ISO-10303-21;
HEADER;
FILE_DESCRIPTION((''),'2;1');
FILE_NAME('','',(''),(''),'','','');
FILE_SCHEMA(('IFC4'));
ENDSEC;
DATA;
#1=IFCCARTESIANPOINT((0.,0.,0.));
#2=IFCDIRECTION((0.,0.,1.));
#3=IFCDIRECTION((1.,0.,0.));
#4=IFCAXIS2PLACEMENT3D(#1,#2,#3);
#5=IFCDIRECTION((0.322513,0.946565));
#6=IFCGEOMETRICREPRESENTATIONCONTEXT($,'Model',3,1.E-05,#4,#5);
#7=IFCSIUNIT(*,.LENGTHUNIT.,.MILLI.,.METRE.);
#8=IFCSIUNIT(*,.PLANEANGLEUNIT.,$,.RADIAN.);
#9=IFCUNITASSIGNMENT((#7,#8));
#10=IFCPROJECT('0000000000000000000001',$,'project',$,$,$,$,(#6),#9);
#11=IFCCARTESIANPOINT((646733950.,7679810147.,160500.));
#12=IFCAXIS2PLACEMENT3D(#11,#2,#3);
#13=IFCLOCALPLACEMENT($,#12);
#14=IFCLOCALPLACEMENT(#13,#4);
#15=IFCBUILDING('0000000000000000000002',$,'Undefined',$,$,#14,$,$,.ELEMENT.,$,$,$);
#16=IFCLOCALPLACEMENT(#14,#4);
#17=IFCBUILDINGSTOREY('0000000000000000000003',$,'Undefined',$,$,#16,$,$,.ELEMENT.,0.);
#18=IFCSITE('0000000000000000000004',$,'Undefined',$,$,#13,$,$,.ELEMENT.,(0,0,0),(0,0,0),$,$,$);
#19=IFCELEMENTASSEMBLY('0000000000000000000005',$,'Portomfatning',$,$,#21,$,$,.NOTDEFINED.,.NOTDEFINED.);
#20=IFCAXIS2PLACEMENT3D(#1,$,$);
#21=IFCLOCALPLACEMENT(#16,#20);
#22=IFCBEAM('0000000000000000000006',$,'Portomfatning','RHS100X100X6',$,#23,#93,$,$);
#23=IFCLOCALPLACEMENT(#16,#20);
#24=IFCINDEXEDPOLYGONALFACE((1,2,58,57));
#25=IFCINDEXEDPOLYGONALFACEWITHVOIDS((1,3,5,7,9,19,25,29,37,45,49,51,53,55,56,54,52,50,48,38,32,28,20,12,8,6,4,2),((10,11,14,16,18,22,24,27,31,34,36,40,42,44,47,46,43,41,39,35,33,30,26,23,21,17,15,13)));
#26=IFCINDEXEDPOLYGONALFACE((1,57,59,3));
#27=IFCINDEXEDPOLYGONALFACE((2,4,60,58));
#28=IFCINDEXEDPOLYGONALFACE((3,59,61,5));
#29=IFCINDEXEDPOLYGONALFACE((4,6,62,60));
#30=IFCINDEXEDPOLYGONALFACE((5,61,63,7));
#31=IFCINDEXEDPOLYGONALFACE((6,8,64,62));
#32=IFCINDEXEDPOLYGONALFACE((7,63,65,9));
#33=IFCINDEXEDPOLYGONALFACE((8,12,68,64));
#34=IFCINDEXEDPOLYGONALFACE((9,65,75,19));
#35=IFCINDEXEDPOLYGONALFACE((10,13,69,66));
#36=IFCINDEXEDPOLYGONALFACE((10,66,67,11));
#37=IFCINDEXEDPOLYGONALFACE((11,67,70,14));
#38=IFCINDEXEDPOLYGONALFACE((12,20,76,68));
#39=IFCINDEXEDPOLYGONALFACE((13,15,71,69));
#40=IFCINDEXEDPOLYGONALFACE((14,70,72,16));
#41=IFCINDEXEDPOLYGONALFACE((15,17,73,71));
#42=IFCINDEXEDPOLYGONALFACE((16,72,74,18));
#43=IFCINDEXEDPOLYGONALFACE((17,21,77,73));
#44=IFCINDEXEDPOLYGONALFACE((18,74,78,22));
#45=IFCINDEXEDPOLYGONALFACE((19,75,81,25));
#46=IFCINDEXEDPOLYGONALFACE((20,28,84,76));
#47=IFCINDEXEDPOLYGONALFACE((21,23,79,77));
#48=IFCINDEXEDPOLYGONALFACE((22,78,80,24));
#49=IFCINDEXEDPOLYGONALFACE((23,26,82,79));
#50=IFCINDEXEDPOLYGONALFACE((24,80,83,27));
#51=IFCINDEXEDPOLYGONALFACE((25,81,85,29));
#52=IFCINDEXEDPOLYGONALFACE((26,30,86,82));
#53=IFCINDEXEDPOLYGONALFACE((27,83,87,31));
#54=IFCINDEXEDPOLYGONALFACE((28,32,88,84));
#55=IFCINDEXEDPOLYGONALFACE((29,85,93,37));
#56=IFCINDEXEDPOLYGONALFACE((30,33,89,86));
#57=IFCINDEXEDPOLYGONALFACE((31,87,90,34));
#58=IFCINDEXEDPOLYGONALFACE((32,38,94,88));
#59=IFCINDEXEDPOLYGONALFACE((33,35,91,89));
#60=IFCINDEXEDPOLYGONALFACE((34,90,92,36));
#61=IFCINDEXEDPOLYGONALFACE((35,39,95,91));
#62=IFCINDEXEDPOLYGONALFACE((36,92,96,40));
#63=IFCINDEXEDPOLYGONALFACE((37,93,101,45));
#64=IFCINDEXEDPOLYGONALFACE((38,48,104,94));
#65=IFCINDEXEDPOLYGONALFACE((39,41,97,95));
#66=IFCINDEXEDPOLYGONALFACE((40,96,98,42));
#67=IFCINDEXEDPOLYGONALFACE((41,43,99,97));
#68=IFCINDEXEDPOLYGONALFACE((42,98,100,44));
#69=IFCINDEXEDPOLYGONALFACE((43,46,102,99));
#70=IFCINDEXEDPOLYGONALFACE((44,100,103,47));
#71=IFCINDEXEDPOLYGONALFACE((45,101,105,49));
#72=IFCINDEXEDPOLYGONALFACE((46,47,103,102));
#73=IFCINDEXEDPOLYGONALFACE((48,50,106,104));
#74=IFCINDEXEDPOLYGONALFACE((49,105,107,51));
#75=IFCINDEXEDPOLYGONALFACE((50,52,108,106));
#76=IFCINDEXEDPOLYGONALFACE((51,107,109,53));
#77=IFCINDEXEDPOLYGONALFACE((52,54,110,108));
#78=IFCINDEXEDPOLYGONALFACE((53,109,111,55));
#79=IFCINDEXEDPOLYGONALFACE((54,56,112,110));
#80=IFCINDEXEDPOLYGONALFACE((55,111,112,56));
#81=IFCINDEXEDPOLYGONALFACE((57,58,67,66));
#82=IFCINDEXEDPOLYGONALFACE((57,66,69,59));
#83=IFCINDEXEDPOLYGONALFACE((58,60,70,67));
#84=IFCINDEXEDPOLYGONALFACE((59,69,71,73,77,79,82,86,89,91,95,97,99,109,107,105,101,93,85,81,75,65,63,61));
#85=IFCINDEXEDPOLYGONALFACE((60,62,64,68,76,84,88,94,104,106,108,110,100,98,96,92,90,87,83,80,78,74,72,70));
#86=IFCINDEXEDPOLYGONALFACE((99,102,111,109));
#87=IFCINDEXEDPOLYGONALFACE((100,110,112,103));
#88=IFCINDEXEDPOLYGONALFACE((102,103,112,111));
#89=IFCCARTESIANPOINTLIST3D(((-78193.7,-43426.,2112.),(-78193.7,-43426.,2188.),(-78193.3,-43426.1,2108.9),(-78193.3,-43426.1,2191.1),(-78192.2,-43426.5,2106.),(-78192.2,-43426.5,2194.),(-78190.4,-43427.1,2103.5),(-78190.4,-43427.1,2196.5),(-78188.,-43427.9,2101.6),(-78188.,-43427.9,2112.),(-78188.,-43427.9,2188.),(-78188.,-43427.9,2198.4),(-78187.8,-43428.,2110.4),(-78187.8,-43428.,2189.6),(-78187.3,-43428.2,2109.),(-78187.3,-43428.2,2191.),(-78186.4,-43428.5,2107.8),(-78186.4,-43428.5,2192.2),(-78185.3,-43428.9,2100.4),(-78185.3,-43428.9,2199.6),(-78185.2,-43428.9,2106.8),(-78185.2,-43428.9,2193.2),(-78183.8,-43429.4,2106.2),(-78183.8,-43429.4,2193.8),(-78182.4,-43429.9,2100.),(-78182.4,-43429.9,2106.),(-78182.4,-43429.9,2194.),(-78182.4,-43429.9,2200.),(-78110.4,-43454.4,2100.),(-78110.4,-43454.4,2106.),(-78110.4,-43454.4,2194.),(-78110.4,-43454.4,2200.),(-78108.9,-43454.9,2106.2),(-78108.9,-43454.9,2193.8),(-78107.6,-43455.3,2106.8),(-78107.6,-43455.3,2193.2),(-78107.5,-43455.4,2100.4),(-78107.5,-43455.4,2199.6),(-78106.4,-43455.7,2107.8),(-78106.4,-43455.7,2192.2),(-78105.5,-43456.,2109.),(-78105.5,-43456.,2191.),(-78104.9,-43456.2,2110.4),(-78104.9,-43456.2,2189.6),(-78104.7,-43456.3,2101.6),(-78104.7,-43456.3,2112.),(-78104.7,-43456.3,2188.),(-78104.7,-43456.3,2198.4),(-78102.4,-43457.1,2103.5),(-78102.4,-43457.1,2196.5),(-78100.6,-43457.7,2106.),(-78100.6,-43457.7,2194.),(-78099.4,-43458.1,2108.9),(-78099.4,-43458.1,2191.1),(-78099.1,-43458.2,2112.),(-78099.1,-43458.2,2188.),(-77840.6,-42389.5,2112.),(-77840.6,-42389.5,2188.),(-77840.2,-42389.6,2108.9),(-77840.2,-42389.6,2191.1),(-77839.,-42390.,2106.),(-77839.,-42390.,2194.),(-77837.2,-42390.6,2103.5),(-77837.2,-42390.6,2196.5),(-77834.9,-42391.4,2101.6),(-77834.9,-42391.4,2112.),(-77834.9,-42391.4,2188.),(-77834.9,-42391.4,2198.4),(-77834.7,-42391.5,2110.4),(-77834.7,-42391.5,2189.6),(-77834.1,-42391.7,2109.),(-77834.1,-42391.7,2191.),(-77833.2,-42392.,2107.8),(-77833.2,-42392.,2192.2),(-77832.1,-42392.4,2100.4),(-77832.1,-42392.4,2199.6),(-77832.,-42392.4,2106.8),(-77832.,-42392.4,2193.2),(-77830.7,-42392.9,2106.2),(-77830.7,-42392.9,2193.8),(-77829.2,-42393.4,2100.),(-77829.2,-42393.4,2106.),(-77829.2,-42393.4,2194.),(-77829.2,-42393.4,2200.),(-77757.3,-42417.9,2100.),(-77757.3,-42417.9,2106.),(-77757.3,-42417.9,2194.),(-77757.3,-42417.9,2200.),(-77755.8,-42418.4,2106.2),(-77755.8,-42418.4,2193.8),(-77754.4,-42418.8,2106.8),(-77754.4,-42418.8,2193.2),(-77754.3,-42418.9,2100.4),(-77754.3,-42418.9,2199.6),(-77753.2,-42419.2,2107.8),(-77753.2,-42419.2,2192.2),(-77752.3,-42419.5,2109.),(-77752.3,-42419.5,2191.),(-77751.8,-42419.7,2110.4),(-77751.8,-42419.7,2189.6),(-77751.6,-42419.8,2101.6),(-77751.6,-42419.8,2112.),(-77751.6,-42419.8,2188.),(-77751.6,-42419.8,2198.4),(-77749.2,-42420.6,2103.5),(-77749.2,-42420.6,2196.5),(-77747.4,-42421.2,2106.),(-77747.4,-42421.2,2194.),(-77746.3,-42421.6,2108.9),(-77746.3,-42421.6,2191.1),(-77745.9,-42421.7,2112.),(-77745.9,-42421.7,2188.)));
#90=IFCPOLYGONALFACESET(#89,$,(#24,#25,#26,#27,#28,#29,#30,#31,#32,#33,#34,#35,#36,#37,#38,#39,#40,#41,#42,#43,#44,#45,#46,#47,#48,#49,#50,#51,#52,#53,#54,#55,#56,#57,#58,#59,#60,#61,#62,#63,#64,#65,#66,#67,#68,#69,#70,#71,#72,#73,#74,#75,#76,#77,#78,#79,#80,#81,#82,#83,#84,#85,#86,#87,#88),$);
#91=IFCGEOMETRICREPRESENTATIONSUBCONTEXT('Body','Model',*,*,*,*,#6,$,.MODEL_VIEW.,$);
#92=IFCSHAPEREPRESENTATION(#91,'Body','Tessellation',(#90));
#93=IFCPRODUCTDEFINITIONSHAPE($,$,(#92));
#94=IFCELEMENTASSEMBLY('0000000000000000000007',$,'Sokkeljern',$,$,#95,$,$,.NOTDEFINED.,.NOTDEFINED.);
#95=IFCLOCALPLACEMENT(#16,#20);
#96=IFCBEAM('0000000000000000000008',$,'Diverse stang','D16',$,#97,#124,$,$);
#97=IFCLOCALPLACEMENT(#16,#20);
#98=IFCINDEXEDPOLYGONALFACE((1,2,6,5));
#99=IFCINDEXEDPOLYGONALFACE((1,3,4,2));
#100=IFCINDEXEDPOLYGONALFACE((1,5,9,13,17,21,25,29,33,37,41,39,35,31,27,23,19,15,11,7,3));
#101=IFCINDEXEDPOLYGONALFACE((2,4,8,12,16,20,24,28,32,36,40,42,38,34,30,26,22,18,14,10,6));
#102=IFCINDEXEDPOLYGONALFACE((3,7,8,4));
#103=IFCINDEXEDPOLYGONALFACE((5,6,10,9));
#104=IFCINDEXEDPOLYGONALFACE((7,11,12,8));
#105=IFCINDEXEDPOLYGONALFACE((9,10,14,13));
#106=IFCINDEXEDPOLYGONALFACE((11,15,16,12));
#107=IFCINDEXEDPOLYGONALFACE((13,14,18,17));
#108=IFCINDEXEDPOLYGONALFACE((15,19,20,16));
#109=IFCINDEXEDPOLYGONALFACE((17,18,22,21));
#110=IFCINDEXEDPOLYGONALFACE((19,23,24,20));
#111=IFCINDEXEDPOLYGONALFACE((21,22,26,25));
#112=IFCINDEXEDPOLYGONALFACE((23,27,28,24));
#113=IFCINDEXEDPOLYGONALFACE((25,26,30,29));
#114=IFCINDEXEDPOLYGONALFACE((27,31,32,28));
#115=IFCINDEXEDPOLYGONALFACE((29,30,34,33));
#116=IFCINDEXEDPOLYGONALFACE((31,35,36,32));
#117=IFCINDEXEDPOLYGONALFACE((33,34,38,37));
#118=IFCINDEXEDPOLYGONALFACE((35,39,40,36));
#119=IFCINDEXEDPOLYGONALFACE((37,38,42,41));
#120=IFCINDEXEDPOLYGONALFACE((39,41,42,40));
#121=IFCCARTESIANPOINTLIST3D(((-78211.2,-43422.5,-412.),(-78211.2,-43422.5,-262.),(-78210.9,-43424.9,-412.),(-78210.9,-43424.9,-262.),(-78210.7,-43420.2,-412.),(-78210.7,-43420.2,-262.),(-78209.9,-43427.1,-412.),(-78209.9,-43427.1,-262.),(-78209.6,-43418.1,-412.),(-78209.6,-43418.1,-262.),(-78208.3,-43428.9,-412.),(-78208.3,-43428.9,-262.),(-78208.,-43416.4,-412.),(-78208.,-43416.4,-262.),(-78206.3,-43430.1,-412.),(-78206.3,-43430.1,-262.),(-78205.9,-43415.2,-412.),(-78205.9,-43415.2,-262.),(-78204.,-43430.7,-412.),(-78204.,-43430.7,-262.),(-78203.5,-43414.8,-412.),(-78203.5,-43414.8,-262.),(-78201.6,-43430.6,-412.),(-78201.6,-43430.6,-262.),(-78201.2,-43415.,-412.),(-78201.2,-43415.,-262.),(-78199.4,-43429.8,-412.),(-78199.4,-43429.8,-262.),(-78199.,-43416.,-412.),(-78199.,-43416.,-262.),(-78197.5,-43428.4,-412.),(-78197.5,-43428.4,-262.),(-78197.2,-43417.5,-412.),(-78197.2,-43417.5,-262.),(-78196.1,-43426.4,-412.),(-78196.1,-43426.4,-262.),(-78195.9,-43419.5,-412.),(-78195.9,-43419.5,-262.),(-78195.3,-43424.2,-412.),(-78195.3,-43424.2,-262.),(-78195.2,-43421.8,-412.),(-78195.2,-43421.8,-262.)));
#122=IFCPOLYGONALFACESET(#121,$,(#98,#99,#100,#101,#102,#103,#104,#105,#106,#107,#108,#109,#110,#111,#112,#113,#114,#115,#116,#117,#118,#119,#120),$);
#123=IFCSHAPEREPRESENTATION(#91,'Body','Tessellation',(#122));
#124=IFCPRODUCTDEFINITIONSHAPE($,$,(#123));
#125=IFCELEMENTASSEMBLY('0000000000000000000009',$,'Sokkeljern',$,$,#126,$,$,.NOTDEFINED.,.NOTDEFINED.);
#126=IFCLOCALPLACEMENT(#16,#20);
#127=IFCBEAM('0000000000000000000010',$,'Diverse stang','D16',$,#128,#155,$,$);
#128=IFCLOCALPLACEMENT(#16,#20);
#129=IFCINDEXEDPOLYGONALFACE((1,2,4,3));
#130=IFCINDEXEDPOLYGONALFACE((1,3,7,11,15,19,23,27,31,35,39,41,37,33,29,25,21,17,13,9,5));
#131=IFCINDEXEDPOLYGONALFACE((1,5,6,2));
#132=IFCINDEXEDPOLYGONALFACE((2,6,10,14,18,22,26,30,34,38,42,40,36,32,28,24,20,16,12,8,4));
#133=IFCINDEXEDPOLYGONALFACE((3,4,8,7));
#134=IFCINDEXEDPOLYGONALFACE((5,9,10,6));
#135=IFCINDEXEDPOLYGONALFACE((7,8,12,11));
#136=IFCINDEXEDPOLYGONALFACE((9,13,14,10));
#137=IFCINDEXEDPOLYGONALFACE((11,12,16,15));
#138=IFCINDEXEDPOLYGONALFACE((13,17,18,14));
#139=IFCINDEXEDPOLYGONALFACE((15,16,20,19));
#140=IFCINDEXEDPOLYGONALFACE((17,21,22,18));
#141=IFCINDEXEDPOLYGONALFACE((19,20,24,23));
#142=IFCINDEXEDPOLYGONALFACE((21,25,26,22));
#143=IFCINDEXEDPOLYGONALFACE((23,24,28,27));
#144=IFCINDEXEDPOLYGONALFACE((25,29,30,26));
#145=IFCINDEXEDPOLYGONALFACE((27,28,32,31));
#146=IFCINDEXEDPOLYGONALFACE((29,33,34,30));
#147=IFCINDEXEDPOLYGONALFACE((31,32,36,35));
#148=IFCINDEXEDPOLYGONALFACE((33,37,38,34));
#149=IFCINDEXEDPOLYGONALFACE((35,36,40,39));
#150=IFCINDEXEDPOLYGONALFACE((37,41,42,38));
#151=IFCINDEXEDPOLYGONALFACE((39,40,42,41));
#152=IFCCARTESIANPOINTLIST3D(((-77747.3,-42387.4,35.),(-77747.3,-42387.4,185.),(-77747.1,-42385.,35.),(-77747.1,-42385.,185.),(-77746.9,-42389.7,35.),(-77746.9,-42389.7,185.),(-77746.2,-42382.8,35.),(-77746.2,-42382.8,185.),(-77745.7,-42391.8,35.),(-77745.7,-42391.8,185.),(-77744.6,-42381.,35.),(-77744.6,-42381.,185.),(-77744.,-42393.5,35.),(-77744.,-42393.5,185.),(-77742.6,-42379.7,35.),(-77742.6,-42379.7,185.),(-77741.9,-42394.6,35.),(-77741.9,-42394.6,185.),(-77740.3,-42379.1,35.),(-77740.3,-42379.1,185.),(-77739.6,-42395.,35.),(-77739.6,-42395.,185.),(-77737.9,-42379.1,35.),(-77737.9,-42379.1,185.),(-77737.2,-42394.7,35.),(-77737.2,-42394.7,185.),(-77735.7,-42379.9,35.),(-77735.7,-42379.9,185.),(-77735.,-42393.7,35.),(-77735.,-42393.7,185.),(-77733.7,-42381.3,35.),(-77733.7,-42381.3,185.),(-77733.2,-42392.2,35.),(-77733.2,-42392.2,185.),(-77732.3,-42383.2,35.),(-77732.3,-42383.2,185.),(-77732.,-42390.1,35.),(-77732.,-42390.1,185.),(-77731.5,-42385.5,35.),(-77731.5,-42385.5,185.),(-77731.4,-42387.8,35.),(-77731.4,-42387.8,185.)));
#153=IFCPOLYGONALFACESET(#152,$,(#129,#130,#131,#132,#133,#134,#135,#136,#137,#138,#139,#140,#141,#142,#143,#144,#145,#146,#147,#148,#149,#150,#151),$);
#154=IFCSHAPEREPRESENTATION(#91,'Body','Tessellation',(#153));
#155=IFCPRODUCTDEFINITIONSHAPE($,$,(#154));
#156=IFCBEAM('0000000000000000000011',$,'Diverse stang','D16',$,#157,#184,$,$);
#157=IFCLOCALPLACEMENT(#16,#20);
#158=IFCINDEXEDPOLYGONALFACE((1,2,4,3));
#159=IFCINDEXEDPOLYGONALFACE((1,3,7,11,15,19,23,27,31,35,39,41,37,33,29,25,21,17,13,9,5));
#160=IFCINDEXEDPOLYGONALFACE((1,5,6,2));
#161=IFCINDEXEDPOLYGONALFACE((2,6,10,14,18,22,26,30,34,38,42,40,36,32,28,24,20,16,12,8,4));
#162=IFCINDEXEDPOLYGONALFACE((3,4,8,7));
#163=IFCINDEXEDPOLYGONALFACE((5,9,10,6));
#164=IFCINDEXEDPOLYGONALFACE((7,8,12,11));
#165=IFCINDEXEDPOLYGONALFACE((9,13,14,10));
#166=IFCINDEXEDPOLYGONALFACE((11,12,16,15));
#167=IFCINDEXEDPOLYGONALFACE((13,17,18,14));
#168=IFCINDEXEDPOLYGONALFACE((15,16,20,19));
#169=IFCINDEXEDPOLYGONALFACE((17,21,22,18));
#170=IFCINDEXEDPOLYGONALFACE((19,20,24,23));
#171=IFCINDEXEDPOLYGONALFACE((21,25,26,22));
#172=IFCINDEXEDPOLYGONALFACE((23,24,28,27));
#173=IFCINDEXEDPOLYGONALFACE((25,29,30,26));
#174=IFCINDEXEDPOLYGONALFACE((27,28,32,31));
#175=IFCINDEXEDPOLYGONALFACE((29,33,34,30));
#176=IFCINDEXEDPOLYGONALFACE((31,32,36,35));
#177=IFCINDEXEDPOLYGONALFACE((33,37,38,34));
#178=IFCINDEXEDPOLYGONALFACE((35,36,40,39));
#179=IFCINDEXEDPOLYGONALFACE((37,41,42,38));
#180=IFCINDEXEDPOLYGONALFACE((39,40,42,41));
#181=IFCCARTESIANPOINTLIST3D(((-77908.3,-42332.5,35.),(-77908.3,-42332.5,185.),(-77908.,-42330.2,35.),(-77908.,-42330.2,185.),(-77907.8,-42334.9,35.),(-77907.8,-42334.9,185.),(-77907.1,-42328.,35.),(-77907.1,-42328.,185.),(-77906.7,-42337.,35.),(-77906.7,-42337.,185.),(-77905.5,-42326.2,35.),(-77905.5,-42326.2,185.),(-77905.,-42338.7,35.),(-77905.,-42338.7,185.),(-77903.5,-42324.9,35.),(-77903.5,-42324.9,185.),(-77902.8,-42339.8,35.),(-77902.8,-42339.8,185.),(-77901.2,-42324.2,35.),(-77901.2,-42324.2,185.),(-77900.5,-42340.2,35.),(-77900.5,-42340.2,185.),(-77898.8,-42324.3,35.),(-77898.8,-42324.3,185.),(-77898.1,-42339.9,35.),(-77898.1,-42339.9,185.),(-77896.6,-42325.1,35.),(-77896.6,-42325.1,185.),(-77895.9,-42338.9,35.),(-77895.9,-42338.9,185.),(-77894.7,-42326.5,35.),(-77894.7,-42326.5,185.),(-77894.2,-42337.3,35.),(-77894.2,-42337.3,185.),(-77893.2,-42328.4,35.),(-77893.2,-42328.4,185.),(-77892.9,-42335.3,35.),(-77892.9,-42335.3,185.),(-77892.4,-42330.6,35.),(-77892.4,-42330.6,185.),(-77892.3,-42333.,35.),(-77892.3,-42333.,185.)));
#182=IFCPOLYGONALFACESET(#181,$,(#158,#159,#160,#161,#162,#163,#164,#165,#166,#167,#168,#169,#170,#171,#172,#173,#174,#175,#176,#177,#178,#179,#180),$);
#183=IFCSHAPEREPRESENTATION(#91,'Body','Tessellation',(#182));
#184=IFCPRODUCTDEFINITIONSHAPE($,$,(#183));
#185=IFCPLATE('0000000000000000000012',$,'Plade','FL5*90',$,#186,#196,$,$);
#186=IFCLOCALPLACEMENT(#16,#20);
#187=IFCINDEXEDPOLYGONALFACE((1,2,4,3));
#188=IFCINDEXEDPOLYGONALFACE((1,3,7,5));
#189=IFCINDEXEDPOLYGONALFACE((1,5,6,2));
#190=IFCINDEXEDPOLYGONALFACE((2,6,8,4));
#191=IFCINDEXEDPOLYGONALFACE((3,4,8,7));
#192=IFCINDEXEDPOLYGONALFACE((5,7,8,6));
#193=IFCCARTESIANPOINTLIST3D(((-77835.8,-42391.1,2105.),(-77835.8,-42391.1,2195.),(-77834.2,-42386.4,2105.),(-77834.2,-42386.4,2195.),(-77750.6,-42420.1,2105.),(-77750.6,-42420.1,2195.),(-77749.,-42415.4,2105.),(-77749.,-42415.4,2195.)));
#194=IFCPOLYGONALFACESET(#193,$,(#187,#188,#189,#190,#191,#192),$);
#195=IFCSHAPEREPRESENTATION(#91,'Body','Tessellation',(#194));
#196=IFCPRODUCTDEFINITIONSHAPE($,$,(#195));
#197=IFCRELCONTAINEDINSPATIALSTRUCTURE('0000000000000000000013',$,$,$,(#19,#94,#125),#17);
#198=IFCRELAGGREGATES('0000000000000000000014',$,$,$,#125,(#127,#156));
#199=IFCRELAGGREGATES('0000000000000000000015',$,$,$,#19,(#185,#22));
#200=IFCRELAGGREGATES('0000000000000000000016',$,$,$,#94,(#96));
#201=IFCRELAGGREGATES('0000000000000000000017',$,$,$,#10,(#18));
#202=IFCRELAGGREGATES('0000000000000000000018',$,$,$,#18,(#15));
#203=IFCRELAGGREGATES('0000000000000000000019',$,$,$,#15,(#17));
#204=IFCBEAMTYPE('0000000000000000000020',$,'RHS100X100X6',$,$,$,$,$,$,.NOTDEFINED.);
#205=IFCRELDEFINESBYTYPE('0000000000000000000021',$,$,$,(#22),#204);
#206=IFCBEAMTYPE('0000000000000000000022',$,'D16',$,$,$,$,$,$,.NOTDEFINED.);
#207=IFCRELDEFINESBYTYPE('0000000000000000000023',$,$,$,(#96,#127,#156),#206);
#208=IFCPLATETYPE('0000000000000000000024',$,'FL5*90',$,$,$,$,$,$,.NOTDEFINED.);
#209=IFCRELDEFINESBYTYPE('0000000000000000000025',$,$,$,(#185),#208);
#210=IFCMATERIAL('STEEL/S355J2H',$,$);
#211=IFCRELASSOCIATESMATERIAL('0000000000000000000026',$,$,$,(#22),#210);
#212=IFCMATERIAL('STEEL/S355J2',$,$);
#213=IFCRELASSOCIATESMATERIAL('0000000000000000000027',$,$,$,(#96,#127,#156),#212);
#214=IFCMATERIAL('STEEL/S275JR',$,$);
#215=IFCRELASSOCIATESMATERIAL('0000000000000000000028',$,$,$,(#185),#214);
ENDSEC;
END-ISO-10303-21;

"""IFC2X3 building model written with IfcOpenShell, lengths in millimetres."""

from ifc_helpers import new_model, si_unit, direction, frame, origin_with_axes, origin_2d_with_axis, place, context, subcontext, project, spatial, polyline, hollow_rectangle, circle, outline, extrude, clip, halfspace, material, type_object, element, aggregate, save


model = new_model("IFC2X3")

# Units and contexts
model_context = context("Model", 3, precision=1e-05, world=origin_with_axes(), true_north=direction((0.322513, 0.946565)))
body_context = subcontext(model_context, "Body", "Model", "MODEL_VIEW")
ifc_project = project(units=[si_unit("LENGTHUNIT", "METRE", prefix="MILLI"), si_unit("PLANEANGLEUNIT", "RADIAN")], contexts=[model_context])

# Site, building, storey
site_placement = place(None, frame((646733950.0, 7679810147.0, 160500.0), z_axis=(0.0, 0.0, 1.0), x_axis=(1.0, 0.0, 0.0)))
site = spatial("IfcSite", under=ifc_project, at=site_placement, Name="Undefined", CompositionType="ELEMENT", RefLatitude=(0, 0, 0), RefLongitude=(0, 0, 0))
building_placement = place(site_placement, origin_with_axes())
building = spatial("IfcBuilding", under=site, at=building_placement, Name="Undefined", CompositionType="ELEMENT")
storey_placement = place(building_placement, origin_with_axes())
storey = spatial("IfcBuildingStorey", under=building, at=storey_placement, Name="Undefined", CompositionType="ELEMENT", Elevation=0.0)

# Shared definitions
ifc_material_1 = material(Name="STEEL/S355J2H")

# Element assemblies, beams
assembly_1_placement = place(storey_placement, origin_with_axes())
assembly_1 = element("IfcElementAssembly", 1, at=assembly_1_placement, inside=storey, Name="Portomfatning", AssemblyPlace="NOTDEFINED", PredefinedType="NOTDEFINED")
beam_type_1 = type_object("IfcBeamType", Name="RHS100X100X6", PredefinedType="NOTDEFINED")
beam_1_placement = place(assembly_1_placement, frame((-77788.4, -42391.4, 2150.0), z_axis=(0.946565, -0.322513, 0.0), x_axis=(-0.322513, -0.946565, 0.0)))
beam_1 = element("IfcBeam", 2, at=beam_1_placement, type_object=beam_type_1, material=ifc_material_1, Name="Portomfatning", Description="RHS100X100X6", context=body_context, shape_type="Clipping", body=[
    clip(clip(extrude(hollow_rectangle(XDim=100.0, YDim=100.0, WallThickness=6.0, InnerFilletRadius=6.0, OuterFilletRadius=12.0, at=origin_2d_with_axis()), frame((1171.7, 0.0, 0.0), z_axis=(-1.0, 0.0, 0.0), x_axis=(0.0, -1.0, 0.0)), (0.0, 0.0, 1.0), 1218.3), halfspace(frame((1110.0, 50.0, 0.0), z_axis=(-1.0, 0.0, 0.0), x_axis=(0.0, 0.0, 1.0)), True)), halfspace(frame((15.0, 50.0, -50.0), z_axis=(1.0, 0.0, 0.000185), x_axis=(0.0, -1.0, 0.0)), True)),
])
ifc_material_2 = material(Name="STEEL/S355J2")
assembly_2_placement = place(storey_placement, origin_with_axes())
assembly_2 = element("IfcElementAssembly", 3, at=assembly_2_placement, inside=storey, Name="Sokkeljern", AssemblyPlace="NOTDEFINED", PredefinedType="NOTDEFINED")
beam_type_2 = type_object("IfcBeamType", Name="D16", PredefinedType="NOTDEFINED")
beam_2_placement = place(assembly_2_placement, frame((-78203.2, -43422.8, -262.0), z_axis=(-0.322513, -0.946565, 0.0), x_axis=(0.0, 0.0, -1.0)))
beam_2 = element("IfcBeam", 4, at=beam_2_placement, type_object=beam_type_2, material=ifc_material_2, Name="Diverse stang", Description="D16", context=body_context, shape_type="SweptSolid", body=[
    extrude(circle(Radius=8.0, at=origin_2d_with_axis()), frame((150.0, 0.0, 0.0), z_axis=(-1.0, 0.0, 0.0), x_axis=(0.0, -1.0, 0.0)), (0.0, 0.0, 1.0), 150.0),
])

# Element assembly, beams
assembly_3_placement = place(storey_placement, origin_with_axes())
assembly_3 = element("IfcElementAssembly", 5, at=assembly_3_placement, inside=storey, Name="Sokkeljern", AssemblyPlace="NOTDEFINED", PredefinedType="NOTDEFINED")
beam_3_placement = place(assembly_3_placement, frame((-77739.3, -42387.0, 185.0), z_axis=(0.946565, -0.322513, 0.0), x_axis=(0.0, 0.0, -1.0)))
beam_3 = element("IfcBeam", 6, at=beam_3_placement, type_object=beam_type_2, material=ifc_material_2, Name="Diverse stang", Description="D16", context=body_context, shape_type="SweptSolid", body=[
    extrude(circle(Radius=8.0, at=origin_2d_with_axis()), frame((150.0, 0.0, 0.0), z_axis=(-1.0, 0.0, 0.0), x_axis=(0.0, -1.0, 0.0)), (0.0, 0.0, 1.0), 150.0),
])
beam_4_placement = place(assembly_3_placement, frame((-77900.3, -42332.2, 185.0), z_axis=(0.946565, -0.322513, 0.0), x_axis=(0.0, 0.0, -1.0)))
beam_4 = element("IfcBeam", 7, at=beam_4_placement, type_object=beam_type_2, material=ifc_material_2, Name="Diverse stang", Description="D16", context=body_context, shape_type="SweptSolid", body=[
    extrude(circle(Radius=8.0, at=origin_2d_with_axis()), frame((150.0, 0.0, 0.0), z_axis=(-1.0, 0.0, 0.0), x_axis=(0.0, -1.0, 0.0)), (0.0, 0.0, 1.0), 150.0),
])
aggregate(assembly_3, [beam_3, beam_4])

# Plate
ifc_material_3 = material(Name="STEEL/S275JR")
plate_type_1 = type_object("IfcPlateType", Name="FL5*90", PredefinedType="NOTDEFINED")
plate_1_placement = place(assembly_1_placement, frame((-77749.8, -42417.8, 2195.0), z_axis=(0.322338, 0.946625, 0.0), x_axis=(0.0, 0.0, -1.0)))
plate_1 = element("IfcPlate", 8, at=plate_1_placement, type_object=plate_type_1, material=ifc_material_3, Name="Plade", Description="FL5*90", context=body_context, shape_type="SweptSolid", body=[
    extrude(outline(polyline([(0.0, 0.0), (90.0, 0.0), (90.0, 90.0), (0.0, 90.0), (0.0, 0.0)])), frame((0.0, 0.0, -2.5), z_axis=(0.0, 0.0, 1.0), x_axis=(1.0, 0.0, 0.0)), (0.0, 0.0, 1.0), 5.0),
])
aggregate(assembly_1, [plate_1, beam_1])

aggregate(assembly_2, [beam_2])

save(model, "model.ifc")
